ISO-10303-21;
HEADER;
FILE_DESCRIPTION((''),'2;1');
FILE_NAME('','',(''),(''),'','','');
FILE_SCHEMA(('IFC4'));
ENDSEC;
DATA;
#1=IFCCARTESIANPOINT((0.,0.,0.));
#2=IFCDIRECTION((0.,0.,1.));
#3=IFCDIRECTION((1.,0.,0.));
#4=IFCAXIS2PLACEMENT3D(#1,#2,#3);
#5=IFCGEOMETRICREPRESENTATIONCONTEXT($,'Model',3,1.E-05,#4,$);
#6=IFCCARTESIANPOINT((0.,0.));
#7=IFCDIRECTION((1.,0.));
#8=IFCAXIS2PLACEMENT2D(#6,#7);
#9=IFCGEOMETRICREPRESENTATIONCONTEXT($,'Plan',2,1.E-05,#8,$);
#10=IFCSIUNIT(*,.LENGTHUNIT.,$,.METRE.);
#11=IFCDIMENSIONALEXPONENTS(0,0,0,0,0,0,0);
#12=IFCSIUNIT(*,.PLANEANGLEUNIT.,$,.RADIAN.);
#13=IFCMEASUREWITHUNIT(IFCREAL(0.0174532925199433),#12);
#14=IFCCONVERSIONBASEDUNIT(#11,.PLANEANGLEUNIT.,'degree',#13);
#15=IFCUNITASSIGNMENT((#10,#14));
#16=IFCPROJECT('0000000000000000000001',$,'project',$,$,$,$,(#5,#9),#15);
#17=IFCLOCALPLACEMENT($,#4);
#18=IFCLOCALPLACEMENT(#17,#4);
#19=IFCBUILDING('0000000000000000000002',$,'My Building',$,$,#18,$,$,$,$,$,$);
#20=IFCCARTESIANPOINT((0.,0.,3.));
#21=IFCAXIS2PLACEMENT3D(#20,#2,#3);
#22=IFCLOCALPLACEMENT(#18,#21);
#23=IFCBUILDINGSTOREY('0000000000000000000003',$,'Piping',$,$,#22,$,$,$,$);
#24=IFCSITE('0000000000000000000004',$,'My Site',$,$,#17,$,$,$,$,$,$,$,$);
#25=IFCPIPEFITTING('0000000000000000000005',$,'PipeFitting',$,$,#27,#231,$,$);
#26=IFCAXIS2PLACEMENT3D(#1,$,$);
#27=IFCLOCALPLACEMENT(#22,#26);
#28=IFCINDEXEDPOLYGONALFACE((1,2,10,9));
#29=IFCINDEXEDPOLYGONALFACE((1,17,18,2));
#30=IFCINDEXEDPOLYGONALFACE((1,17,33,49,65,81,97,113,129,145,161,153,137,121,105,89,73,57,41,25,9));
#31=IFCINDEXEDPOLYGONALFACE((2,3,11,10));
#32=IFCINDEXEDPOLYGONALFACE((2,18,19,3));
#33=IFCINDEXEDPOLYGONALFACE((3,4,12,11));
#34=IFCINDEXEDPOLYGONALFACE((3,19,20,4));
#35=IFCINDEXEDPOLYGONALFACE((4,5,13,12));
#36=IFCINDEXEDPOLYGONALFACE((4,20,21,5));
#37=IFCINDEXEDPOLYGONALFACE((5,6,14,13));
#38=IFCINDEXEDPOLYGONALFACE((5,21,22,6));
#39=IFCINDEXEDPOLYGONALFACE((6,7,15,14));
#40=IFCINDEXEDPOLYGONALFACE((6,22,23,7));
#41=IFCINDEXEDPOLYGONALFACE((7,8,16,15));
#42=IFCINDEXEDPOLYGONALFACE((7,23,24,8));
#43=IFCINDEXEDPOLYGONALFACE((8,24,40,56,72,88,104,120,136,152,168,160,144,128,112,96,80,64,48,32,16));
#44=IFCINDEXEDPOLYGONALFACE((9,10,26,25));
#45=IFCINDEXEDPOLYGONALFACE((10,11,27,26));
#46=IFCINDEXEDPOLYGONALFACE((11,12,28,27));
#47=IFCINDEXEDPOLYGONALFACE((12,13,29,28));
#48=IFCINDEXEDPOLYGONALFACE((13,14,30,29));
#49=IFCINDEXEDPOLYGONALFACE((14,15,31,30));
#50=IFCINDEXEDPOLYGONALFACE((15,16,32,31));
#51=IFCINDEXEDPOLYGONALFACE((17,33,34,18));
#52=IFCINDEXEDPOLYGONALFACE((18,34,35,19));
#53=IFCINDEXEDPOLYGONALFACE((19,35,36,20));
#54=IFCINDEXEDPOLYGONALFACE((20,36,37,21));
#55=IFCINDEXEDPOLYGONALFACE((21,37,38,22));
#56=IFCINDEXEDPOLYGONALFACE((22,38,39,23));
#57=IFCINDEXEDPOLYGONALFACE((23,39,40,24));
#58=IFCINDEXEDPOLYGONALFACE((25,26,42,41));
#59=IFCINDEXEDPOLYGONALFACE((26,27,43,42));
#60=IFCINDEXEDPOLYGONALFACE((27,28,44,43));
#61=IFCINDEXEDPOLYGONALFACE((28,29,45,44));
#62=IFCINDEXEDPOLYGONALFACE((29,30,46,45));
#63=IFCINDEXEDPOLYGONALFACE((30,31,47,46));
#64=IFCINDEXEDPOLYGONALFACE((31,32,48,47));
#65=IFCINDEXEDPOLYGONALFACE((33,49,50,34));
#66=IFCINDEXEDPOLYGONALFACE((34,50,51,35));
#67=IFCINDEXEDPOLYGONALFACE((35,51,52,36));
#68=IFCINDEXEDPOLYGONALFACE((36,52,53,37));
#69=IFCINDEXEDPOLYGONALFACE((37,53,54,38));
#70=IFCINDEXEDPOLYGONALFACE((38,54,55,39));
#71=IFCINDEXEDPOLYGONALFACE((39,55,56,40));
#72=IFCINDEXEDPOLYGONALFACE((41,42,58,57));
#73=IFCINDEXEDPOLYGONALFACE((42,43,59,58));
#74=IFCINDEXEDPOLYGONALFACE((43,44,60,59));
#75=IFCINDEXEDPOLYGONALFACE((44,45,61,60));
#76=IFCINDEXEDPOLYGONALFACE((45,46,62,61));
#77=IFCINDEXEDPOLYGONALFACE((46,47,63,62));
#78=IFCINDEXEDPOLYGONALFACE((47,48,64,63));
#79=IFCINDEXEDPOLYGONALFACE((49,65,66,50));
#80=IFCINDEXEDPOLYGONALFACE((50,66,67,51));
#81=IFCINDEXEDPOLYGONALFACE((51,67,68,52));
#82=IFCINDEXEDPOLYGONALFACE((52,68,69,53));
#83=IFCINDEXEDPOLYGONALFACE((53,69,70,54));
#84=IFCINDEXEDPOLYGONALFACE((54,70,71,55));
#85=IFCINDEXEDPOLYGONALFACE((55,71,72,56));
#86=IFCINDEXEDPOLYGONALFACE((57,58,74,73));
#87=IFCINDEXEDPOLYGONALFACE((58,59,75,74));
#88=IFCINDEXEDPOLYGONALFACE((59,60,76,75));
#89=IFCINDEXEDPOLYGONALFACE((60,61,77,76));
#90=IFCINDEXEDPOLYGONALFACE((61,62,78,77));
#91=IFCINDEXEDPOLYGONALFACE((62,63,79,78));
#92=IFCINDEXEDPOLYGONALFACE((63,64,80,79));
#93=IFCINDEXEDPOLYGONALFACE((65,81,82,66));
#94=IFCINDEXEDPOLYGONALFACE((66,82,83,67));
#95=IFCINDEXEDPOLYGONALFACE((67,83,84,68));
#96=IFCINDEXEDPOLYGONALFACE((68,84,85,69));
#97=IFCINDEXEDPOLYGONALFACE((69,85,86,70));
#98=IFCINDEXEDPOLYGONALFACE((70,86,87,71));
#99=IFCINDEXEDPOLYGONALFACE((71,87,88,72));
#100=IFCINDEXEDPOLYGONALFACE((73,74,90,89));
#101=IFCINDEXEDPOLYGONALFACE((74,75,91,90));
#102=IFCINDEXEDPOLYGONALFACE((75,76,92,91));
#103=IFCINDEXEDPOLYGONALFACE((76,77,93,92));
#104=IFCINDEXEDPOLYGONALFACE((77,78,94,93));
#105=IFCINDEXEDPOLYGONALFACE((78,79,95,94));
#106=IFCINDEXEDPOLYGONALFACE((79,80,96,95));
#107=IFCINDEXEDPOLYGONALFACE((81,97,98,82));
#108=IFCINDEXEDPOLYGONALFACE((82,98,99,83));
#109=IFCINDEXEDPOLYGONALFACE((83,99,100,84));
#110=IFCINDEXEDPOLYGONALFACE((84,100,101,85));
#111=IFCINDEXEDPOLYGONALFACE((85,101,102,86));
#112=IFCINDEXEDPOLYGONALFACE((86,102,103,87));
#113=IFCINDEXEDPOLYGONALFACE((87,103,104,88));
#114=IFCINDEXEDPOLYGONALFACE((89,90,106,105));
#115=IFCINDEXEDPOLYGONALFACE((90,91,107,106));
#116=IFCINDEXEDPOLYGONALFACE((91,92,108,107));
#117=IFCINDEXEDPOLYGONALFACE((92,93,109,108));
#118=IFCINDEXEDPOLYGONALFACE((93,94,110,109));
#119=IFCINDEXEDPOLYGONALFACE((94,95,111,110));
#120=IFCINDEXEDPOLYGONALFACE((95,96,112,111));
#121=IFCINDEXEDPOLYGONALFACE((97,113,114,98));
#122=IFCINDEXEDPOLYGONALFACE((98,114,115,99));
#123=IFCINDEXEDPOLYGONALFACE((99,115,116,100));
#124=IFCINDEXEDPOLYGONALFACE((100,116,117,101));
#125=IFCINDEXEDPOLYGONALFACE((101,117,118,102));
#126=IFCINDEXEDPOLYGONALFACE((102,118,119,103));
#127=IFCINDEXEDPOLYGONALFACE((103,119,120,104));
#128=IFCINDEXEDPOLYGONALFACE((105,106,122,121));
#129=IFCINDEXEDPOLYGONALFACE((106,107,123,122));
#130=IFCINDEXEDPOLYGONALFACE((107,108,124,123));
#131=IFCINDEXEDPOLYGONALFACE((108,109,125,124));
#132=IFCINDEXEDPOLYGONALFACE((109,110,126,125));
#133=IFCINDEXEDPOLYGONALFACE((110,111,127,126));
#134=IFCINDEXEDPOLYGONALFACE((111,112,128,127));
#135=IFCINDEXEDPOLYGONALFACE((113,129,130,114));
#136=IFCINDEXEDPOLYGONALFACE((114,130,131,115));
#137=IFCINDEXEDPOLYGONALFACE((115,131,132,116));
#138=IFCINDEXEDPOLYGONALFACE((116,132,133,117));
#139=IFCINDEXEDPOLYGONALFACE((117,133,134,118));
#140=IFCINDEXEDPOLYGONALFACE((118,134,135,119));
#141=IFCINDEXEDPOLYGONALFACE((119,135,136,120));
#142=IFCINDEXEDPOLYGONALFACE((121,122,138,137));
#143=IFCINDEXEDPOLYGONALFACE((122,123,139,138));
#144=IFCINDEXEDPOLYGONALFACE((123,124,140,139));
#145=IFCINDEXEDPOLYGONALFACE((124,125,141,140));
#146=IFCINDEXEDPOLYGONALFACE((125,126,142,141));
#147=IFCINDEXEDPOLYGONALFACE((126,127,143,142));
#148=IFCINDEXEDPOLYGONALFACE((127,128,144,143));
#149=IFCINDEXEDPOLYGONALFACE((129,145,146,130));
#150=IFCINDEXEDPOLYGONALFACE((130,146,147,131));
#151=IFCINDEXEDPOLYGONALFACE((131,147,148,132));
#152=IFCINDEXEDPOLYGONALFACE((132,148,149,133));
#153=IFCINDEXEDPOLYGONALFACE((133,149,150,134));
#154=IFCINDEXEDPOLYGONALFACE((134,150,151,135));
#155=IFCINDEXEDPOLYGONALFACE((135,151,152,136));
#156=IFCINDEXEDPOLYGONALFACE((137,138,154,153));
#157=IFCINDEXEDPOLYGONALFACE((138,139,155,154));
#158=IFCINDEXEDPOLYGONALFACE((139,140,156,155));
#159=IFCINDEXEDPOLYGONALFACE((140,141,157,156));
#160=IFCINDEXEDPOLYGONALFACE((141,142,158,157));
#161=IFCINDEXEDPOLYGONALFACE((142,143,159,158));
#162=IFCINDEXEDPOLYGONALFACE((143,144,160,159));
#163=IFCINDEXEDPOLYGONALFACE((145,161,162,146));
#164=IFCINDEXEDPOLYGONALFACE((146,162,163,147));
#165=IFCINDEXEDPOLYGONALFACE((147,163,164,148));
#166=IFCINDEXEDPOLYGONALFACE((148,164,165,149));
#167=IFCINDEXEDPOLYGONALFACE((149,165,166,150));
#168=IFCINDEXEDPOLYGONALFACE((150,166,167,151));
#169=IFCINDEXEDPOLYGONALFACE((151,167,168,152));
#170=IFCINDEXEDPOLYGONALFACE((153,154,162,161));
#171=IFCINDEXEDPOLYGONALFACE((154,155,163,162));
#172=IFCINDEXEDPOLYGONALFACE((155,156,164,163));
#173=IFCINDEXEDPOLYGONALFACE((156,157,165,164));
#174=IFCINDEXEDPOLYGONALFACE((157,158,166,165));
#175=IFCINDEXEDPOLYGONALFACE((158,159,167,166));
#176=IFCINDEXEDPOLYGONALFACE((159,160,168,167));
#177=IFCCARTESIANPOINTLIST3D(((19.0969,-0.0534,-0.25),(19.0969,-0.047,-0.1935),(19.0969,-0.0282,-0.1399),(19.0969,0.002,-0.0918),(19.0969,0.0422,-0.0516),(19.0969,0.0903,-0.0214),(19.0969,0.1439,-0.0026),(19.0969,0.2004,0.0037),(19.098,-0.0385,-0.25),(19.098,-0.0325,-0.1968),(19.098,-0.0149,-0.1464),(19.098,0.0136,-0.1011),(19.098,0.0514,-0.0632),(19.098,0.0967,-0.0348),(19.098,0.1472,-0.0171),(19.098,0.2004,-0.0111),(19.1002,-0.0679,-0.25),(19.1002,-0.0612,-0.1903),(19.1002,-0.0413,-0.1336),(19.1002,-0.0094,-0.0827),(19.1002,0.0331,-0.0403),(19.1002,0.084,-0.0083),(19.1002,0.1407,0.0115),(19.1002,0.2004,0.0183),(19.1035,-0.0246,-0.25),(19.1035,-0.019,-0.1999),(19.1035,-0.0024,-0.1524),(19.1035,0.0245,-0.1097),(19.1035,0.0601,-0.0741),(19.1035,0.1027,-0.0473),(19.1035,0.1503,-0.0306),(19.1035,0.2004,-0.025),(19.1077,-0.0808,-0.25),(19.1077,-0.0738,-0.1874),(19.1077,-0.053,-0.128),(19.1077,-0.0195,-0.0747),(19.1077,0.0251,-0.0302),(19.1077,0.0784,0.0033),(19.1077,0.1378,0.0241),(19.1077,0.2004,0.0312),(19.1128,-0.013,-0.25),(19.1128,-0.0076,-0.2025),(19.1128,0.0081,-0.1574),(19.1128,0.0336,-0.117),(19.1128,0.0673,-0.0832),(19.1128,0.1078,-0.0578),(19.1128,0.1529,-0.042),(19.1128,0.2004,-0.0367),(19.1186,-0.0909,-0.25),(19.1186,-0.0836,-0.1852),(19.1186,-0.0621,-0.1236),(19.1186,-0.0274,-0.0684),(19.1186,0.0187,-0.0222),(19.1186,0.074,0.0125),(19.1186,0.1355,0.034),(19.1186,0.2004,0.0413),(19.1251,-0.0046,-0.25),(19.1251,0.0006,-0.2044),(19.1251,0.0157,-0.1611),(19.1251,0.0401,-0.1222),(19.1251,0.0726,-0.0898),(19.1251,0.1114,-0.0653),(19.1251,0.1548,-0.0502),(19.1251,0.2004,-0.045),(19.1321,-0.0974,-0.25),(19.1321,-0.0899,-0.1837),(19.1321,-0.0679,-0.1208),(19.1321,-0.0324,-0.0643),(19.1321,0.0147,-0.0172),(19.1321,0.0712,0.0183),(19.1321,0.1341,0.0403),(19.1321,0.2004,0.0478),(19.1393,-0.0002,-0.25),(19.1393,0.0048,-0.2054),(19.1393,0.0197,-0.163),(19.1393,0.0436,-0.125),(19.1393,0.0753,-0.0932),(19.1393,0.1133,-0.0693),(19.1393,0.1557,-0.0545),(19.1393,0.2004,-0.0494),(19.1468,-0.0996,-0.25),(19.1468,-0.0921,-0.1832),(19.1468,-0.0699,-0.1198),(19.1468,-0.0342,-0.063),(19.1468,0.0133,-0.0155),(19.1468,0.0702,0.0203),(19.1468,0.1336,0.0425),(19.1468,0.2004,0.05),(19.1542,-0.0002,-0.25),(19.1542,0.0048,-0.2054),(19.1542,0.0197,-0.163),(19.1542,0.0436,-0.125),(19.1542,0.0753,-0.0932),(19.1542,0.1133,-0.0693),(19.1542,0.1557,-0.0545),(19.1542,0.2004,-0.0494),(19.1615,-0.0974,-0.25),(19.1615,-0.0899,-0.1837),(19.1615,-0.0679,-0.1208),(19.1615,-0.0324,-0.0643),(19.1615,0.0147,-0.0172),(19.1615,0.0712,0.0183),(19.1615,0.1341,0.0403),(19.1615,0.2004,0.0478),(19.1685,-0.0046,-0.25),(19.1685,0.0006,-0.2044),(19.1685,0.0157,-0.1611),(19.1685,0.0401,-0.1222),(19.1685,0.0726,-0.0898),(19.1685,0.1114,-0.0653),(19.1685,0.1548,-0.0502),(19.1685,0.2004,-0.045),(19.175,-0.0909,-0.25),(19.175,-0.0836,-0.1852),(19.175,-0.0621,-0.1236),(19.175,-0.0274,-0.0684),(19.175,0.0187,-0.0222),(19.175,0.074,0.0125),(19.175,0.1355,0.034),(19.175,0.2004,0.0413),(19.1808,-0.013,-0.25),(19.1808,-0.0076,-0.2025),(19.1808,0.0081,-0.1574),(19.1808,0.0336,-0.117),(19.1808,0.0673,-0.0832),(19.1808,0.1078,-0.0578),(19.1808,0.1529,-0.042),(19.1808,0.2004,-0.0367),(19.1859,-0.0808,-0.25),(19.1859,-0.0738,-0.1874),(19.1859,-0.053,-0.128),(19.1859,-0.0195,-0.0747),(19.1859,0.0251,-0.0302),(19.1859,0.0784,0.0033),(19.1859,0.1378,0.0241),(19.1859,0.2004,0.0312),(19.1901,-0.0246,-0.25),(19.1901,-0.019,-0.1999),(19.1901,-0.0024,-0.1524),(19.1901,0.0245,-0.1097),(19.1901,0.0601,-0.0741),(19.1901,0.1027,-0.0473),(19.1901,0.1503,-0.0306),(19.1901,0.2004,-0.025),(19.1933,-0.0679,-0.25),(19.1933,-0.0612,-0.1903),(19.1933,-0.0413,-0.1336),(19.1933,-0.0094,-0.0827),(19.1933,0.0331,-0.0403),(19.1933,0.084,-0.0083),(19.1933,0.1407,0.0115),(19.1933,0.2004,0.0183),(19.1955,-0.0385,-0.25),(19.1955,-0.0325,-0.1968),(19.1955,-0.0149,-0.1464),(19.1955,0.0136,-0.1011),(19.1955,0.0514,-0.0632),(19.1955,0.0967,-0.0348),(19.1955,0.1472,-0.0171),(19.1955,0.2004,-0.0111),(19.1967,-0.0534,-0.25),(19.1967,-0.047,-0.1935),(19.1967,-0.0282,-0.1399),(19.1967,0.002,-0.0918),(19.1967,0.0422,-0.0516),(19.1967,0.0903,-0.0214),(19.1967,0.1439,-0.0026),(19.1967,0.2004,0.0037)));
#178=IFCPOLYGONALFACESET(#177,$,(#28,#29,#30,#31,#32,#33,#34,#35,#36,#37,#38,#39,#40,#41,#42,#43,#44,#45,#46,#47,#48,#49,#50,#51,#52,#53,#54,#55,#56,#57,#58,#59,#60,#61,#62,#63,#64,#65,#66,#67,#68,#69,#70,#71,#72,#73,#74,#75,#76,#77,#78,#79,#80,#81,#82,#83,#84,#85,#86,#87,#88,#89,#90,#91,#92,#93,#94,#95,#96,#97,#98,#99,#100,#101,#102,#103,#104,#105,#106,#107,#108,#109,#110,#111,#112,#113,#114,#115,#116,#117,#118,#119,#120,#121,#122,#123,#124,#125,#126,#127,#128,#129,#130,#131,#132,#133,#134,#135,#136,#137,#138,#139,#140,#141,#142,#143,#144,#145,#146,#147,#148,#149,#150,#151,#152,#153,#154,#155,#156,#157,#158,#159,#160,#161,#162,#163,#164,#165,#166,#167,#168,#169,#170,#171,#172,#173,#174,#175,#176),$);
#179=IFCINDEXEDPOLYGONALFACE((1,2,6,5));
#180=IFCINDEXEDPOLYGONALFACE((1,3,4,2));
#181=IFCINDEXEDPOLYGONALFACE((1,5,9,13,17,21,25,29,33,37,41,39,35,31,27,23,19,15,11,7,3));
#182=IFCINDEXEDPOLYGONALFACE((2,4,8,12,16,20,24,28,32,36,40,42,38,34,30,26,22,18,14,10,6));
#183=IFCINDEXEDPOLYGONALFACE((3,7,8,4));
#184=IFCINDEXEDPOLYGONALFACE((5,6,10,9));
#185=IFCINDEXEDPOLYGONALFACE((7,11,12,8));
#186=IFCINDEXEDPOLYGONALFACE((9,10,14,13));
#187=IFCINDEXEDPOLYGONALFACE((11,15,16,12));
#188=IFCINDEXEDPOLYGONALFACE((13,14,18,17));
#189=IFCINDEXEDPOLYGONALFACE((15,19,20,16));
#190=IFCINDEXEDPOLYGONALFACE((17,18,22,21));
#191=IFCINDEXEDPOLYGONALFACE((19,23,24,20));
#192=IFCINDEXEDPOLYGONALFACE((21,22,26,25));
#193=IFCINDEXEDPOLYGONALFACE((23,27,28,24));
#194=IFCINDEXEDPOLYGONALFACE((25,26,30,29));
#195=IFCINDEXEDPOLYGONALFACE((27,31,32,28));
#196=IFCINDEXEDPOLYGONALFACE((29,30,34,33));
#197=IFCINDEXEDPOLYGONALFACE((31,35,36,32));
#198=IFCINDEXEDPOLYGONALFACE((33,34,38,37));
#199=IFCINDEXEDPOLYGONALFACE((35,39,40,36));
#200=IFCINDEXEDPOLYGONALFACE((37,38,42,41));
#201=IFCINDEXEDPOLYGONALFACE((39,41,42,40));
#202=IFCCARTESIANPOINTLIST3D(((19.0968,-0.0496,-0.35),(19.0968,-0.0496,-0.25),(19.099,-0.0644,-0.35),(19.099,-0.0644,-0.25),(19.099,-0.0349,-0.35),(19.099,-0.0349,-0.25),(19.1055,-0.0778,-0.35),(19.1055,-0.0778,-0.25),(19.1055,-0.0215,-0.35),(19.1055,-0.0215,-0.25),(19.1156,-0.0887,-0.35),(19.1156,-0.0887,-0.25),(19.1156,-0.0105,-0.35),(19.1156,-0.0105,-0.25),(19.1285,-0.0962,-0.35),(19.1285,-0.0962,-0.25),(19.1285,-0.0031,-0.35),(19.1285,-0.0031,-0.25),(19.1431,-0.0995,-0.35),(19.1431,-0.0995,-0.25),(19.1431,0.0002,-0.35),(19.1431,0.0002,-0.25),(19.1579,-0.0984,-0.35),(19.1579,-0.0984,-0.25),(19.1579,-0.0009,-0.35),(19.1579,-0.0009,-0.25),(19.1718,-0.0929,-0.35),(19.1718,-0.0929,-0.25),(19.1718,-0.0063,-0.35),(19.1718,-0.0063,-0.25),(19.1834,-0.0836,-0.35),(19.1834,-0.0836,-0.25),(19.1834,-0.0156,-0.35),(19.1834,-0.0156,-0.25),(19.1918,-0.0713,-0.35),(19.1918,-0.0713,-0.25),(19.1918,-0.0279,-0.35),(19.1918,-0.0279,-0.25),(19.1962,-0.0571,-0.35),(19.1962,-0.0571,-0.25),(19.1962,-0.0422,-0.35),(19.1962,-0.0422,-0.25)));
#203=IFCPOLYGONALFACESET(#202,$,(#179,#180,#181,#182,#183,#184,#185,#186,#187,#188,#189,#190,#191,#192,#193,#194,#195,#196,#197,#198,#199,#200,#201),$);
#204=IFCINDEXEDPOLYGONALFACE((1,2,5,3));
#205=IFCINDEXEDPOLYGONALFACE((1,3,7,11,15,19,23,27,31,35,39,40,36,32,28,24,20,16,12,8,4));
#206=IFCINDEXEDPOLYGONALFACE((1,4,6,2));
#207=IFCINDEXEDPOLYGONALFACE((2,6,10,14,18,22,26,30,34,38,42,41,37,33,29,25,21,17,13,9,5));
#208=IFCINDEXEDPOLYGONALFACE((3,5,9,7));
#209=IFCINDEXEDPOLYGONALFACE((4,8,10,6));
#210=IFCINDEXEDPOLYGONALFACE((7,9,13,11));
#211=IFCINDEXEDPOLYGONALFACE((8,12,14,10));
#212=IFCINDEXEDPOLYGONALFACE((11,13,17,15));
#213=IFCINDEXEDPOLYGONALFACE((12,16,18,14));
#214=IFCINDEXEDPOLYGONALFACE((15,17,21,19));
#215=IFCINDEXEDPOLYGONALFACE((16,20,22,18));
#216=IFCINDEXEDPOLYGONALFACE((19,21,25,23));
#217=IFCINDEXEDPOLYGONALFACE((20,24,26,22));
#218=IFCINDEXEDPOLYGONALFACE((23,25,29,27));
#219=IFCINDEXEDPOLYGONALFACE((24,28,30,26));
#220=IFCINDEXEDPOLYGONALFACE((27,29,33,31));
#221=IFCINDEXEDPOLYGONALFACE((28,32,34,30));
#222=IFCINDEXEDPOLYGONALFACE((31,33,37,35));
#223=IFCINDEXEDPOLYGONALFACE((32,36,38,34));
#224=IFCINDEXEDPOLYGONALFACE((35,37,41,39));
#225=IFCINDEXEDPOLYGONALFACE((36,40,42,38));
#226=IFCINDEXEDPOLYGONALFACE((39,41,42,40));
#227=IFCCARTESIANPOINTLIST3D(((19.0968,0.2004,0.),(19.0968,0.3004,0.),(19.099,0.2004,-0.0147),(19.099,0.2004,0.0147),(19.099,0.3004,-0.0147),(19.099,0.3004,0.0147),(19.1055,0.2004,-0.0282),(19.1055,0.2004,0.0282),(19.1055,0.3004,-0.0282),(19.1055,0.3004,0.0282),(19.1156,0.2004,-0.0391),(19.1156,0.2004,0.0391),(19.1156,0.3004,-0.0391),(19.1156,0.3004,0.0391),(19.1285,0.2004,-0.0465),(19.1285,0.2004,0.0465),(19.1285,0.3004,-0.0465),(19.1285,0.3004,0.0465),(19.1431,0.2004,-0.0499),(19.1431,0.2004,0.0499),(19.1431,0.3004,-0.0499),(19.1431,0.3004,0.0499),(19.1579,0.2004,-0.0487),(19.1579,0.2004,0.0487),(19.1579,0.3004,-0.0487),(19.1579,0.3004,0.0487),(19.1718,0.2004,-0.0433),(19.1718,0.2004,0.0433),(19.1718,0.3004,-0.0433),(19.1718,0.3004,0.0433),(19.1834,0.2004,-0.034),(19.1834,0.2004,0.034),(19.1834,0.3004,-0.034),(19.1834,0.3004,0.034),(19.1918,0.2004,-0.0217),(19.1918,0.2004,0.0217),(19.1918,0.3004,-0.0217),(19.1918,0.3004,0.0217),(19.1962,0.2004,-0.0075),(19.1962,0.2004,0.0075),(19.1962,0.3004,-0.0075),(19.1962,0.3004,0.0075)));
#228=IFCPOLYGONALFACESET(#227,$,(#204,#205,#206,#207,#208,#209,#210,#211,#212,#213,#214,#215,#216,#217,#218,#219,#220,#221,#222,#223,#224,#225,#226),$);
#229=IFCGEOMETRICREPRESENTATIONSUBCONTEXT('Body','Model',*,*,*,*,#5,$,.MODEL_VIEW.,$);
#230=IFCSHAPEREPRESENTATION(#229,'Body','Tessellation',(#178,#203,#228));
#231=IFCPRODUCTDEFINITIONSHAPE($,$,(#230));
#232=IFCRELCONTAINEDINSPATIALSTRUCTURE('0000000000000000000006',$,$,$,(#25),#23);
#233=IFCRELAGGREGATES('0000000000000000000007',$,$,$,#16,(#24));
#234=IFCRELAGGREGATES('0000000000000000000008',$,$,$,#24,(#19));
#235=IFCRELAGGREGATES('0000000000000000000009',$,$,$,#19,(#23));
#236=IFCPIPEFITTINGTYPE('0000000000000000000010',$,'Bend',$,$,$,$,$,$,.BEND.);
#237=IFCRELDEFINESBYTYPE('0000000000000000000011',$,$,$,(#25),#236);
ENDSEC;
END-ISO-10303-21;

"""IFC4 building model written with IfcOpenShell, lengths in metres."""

from ifc_helpers import new_model, entity, si_unit, converted_unit, frame, origin_with_axes, origin_2d_with_axis, place, context, subcontext, project, spatial, circle, extrude, source, transform, mapped, type_object, type_shapes, element, save


model = new_model("IFC4")

# Units and contexts
model_context = context("Model", 3, precision=1e-05, world=origin_with_axes())
plan_context = context("Plan", 2, precision=1e-05, world=origin_2d_with_axis())
body_context = subcontext(model_context, "Body", "Model", "MODEL_VIEW")
ifc_project = project(units=[si_unit("LENGTHUNIT", "METRE"), converted_unit("PLANEANGLEUNIT", "degree", entity("IfcReal", 0.0174532925199433), si_unit("PLANEANGLEUNIT", "RADIAN"), dimensions=[0, 0, 0, 0, 0, 0, 0])], contexts=[model_context, plan_context])

# Site, building, storey
site_placement = place(None, origin_with_axes())
site = spatial("IfcSite", under=ifc_project, at=site_placement, Name="My Site")
building_placement = place(site_placement, origin_with_axes())
building = spatial("IfcBuilding", under=site, at=building_placement, Name="My Building")
storey_placement = place(building_placement, frame((0.0, 0.0, 3.0), z_axis=(0.0, 0.0, 1.0), x_axis=(1.0, 0.0, 0.0)))
storey = spatial("IfcBuildingStorey", under=building, at=storey_placement, Name="Piping")

# Pipe fitting
pipe_fitting_type_1 = type_object("IfcPipeFittingType", Name="Bend", PredefinedType="BEND")
shared_shape = source(origin_with_axes(), body_context, "Body", "SolidModel", [
    entity("IfcSweptDiskSolid", entity("IfcIndexedPolyCurve", entity("IfcCartesianPointList3D", [[0.0, 0.0, -0.1], [0.0, 0.0732, -0.2768], [0.0, 0.25, -0.35]]), [entity("IfcArcIndex", [1, 2, 3])]), 0.05),
    extrude(circle(Radius=0.05), origin_with_axes(), (0.0, 0.0, -1.0), 0.1),
    extrude(circle(Radius=0.05), frame((0.0, 0.25, -0.35), z_axis=(0.0, 1.0, 0.0), x_axis=(1.0, 0.0, 0.0)), (0.0, 0.0, 1.0), 0.1),
])
type_shapes(pipe_fitting_type_1, [shared_shape])
for number, where, z_axis, x_axis, name in (
    (1, (19.1468, -0.0496, -0.35), (0.0, 0.0, -1.0), (-1.0, 0.0, 0.0), "PipeFitting"),
):
    element("IfcPipeFitting", number, at=place(storey_placement, frame(where, z_axis=z_axis, x_axis=x_axis)), inside=storey, type_object=pipe_fitting_type_1, Name=name, context=body_context, shape_type="MappedRepresentation", body=[
        mapped(shared_shape, transform((0.0, 0.0, 0.0), x_axis=(1.0, 0.0, 0.0), y_axis=(0.0, 1.0, 0.0), z_axis=(0.0, 0.0, 1.0), scale=1.0)),
    ])

save(model, "model.ifc")
